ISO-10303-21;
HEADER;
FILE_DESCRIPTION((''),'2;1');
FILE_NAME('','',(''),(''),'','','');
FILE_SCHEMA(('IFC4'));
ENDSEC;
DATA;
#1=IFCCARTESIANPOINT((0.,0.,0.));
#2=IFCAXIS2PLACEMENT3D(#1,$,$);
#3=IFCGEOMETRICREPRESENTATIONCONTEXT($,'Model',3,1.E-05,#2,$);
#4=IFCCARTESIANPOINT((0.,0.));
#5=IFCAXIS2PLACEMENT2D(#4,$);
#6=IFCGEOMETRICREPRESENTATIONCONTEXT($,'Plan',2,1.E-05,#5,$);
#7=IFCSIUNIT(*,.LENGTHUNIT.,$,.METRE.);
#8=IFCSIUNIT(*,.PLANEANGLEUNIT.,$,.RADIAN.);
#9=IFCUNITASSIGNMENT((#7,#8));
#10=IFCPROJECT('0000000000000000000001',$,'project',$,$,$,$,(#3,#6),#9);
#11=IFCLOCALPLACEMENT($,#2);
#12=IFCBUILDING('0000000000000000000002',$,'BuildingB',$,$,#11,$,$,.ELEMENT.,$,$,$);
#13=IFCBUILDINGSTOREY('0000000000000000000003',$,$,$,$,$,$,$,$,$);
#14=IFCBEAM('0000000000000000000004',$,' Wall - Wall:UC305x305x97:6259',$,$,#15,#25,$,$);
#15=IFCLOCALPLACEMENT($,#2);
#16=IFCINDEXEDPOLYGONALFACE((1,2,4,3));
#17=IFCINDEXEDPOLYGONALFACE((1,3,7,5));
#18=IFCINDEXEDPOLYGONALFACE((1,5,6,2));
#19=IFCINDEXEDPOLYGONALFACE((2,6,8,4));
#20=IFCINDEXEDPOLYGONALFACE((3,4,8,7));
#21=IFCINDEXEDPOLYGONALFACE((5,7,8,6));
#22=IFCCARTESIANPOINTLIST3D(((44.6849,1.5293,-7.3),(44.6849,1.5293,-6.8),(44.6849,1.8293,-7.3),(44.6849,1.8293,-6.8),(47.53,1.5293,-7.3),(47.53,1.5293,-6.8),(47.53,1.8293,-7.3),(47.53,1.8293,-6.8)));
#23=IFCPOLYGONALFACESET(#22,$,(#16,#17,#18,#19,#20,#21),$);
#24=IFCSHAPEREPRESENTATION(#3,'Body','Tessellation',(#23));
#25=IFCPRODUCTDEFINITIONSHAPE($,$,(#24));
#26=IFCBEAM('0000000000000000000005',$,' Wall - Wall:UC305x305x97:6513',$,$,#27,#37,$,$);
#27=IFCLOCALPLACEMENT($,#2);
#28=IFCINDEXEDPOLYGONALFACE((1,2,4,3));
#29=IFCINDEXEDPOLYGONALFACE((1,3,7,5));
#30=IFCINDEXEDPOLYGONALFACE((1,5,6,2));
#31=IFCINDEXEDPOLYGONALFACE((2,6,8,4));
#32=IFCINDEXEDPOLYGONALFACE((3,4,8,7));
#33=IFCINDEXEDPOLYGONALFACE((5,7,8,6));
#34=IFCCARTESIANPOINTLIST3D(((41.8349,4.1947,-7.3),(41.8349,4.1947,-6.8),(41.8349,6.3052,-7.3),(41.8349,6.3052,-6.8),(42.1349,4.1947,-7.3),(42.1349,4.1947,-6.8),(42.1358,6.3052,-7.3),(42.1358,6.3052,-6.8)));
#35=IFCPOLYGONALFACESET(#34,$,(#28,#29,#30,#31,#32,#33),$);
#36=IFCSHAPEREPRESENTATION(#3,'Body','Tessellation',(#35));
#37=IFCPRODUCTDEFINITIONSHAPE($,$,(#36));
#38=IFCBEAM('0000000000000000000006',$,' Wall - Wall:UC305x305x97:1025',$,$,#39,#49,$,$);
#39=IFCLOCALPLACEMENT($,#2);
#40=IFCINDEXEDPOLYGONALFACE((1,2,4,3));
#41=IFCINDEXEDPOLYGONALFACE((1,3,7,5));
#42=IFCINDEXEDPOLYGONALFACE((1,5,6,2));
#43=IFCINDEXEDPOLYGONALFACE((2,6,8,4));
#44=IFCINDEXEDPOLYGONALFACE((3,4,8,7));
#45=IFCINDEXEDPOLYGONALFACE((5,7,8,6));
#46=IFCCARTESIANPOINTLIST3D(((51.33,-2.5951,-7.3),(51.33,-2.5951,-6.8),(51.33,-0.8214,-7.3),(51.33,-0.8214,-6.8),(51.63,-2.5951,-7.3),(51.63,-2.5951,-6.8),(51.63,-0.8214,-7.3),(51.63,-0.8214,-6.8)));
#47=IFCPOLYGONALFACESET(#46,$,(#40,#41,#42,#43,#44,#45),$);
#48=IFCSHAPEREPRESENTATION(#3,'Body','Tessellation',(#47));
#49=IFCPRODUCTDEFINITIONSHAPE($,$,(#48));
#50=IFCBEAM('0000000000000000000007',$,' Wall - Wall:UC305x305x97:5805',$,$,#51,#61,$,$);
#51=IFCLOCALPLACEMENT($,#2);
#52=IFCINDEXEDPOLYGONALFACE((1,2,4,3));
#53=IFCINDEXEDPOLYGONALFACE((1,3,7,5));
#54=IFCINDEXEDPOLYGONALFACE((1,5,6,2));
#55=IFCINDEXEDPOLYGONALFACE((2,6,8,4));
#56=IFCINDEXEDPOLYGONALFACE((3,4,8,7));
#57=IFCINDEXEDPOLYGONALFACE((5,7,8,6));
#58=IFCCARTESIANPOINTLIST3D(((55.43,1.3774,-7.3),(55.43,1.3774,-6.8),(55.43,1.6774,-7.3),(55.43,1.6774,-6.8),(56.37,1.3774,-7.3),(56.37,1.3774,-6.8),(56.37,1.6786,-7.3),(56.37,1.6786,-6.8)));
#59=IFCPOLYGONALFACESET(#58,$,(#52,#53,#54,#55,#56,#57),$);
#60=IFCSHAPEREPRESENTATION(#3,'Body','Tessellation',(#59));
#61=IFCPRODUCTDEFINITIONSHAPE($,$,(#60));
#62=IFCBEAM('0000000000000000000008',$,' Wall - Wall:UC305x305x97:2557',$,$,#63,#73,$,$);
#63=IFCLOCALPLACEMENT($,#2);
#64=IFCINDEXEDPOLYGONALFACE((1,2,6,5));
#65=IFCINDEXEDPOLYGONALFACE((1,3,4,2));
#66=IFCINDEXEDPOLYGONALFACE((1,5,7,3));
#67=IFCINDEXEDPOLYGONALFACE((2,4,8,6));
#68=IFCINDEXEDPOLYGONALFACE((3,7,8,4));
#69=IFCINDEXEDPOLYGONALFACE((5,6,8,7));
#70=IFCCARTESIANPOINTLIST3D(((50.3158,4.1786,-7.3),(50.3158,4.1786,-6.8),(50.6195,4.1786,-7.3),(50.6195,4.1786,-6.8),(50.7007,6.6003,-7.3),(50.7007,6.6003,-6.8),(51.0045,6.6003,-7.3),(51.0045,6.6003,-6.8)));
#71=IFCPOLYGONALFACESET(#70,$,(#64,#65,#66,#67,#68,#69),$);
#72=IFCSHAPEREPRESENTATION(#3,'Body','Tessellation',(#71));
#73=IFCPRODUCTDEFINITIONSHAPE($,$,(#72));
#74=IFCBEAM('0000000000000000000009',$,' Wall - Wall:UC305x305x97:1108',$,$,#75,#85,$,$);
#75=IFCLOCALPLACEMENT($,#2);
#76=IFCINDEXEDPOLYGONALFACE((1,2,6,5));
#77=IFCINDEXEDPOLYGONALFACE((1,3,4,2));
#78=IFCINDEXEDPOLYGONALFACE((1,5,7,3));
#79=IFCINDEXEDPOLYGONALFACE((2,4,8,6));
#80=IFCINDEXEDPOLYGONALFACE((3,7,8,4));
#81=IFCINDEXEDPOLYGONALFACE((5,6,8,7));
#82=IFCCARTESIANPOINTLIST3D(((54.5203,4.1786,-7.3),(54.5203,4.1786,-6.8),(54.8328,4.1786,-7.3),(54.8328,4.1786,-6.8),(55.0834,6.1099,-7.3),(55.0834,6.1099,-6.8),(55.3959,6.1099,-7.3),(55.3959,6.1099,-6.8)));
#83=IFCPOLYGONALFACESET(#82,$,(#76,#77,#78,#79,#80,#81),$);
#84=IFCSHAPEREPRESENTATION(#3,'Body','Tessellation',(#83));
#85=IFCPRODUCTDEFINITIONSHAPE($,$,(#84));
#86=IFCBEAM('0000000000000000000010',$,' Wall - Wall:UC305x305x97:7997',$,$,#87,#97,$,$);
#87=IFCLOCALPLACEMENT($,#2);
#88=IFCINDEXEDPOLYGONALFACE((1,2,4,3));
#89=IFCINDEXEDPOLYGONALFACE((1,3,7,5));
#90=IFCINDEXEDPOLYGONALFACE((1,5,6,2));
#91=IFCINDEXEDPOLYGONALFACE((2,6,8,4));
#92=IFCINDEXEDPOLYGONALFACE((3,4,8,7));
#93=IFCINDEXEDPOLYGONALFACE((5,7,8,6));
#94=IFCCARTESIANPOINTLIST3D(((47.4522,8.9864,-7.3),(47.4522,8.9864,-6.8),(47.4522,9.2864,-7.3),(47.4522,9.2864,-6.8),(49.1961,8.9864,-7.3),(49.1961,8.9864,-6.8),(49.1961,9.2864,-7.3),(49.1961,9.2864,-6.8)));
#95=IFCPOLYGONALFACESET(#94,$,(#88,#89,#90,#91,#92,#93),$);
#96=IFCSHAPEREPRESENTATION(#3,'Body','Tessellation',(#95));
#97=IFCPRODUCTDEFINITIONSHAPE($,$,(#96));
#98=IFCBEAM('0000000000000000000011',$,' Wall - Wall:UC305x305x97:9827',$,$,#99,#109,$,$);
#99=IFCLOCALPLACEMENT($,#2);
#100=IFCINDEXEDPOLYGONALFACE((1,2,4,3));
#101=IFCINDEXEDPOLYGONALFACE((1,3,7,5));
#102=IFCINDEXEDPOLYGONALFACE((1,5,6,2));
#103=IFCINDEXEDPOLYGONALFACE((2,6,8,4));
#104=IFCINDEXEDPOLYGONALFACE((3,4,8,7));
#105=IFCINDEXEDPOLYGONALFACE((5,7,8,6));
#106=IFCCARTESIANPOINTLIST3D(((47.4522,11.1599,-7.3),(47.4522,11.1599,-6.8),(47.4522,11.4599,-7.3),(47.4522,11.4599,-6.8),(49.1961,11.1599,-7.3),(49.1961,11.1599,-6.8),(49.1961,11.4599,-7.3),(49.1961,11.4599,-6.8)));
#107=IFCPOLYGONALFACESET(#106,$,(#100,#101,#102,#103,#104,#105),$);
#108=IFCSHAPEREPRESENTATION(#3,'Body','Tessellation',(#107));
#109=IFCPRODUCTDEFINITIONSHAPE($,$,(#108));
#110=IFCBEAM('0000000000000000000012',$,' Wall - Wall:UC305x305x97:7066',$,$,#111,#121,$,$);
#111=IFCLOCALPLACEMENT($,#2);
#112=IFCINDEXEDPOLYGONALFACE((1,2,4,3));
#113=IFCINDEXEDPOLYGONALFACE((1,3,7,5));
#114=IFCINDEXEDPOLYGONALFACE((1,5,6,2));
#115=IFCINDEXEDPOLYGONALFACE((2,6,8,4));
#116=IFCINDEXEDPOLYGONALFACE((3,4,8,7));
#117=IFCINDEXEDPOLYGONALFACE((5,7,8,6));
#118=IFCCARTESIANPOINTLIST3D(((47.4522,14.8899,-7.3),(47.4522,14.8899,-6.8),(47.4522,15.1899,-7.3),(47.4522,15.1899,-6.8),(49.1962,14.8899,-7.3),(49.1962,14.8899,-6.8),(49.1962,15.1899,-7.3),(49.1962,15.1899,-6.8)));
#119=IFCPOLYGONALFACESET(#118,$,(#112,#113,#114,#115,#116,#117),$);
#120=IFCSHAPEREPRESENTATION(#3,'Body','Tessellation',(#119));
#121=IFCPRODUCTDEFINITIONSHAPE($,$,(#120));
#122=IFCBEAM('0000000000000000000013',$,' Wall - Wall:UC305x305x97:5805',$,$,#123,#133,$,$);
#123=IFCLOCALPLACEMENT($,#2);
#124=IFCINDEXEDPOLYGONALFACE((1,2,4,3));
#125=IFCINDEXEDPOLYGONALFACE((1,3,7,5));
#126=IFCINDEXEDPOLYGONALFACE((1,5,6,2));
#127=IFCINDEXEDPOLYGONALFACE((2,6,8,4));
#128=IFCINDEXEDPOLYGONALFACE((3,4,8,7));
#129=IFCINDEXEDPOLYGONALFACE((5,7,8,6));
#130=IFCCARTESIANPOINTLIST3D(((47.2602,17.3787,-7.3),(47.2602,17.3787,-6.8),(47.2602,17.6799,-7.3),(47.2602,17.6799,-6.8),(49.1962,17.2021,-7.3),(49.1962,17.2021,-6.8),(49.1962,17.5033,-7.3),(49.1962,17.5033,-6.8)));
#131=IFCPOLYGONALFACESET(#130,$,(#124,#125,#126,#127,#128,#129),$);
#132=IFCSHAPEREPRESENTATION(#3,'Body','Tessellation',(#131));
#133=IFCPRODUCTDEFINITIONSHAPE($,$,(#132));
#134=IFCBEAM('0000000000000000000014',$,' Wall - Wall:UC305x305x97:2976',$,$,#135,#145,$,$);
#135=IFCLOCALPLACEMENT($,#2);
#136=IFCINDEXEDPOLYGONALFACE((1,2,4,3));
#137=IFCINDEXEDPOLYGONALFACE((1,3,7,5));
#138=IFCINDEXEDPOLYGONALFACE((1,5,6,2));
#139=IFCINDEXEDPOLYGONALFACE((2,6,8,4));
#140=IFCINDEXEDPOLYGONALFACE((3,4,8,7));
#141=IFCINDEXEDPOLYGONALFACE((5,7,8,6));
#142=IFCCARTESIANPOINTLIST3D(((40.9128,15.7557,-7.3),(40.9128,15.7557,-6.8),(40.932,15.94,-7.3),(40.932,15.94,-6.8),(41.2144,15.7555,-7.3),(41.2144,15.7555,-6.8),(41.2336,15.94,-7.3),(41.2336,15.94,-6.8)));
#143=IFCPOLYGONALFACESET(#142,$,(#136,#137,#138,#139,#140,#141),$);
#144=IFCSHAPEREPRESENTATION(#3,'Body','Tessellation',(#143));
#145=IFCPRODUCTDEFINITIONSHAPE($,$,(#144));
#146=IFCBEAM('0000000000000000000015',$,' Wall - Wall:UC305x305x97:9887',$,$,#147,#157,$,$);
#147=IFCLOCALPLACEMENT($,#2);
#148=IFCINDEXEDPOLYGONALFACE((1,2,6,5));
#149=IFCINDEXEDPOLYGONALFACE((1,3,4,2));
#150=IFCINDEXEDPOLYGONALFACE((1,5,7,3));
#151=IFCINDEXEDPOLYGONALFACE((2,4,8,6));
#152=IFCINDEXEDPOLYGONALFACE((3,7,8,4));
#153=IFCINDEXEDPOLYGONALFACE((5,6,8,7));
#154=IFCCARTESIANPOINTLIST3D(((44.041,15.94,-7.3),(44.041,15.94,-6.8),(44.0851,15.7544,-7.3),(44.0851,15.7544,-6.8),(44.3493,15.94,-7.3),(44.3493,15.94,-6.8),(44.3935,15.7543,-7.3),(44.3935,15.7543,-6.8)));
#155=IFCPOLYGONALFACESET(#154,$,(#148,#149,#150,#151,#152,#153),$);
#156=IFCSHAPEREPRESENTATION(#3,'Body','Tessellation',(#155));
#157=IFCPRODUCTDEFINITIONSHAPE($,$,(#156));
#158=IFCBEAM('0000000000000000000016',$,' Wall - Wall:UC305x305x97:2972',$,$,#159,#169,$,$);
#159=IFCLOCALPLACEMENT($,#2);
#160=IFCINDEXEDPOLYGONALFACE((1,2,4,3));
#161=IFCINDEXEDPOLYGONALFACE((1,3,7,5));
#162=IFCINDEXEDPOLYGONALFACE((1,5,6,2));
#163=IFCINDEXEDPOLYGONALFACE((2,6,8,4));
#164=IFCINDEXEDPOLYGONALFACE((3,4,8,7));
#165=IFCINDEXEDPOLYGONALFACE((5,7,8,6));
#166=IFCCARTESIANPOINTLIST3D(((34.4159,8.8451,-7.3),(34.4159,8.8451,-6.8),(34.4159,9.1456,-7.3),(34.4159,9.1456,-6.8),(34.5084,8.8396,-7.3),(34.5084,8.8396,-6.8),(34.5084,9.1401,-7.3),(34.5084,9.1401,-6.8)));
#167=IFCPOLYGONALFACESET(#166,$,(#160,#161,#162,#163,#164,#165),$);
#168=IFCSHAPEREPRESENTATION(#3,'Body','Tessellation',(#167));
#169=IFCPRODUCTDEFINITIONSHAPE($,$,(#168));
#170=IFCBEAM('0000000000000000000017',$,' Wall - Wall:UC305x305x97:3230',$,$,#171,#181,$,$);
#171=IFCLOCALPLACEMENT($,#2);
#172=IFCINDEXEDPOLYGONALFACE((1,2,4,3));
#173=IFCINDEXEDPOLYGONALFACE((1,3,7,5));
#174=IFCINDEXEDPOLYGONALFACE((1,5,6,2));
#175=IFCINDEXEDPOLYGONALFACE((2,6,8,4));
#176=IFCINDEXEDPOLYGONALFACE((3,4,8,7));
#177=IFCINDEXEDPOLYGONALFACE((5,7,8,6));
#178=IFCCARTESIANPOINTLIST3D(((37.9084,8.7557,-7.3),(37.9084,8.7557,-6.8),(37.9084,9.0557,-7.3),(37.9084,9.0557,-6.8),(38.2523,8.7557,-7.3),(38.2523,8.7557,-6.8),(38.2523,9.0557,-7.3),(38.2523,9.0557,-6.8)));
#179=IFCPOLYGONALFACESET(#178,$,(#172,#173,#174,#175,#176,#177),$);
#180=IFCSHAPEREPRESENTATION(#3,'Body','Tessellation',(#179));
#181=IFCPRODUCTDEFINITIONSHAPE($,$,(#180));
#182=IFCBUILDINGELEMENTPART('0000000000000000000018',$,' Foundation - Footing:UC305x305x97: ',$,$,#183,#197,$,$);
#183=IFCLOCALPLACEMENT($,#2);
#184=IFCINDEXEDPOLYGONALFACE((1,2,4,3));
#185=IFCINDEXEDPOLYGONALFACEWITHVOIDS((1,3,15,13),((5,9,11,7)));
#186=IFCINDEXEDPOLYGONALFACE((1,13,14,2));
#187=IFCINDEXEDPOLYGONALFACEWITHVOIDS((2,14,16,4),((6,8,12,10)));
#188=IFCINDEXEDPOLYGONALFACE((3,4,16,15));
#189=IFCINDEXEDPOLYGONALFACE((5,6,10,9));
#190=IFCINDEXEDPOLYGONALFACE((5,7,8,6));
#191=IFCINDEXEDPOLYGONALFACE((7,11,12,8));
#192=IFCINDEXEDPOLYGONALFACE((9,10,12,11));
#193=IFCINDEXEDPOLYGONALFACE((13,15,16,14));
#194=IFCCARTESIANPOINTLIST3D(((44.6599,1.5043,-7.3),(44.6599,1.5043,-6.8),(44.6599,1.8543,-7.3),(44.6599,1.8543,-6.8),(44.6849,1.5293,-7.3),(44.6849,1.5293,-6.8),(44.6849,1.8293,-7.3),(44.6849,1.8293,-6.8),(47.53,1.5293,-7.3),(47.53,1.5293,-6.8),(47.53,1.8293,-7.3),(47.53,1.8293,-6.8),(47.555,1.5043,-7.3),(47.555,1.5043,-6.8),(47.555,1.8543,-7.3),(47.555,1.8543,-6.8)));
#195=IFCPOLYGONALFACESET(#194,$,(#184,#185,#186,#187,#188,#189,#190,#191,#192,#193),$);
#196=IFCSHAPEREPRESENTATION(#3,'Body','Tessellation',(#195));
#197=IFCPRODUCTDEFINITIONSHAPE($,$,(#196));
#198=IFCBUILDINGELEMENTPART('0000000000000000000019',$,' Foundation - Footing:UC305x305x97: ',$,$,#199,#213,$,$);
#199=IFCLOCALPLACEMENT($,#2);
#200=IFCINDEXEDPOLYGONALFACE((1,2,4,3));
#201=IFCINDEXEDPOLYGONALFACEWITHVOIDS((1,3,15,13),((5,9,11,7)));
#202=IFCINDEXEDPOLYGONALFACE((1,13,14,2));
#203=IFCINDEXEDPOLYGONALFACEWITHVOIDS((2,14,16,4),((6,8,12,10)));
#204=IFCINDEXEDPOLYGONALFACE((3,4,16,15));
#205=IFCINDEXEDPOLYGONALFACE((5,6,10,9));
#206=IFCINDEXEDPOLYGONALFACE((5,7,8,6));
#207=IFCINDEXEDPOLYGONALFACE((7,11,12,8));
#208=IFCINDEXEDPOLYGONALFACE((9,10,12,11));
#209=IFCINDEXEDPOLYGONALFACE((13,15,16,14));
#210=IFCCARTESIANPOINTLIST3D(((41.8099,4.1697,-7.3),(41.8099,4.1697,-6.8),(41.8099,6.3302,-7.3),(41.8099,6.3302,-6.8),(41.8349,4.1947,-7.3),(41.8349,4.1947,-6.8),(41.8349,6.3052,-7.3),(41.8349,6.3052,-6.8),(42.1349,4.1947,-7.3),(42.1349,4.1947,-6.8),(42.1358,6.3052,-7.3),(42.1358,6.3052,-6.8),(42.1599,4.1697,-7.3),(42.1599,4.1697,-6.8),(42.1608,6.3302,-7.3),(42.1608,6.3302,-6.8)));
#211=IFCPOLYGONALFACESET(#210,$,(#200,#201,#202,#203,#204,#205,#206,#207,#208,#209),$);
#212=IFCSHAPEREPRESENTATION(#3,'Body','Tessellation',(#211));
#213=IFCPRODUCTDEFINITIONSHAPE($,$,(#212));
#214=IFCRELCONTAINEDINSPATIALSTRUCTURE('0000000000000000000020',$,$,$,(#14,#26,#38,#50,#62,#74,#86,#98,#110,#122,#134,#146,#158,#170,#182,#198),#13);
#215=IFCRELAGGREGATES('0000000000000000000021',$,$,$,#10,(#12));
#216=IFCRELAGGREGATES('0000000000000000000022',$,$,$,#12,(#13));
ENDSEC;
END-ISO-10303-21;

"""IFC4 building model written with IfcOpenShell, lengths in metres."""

from ifc_helpers import new_model, si_unit, origin, origin_2d, place, context, project, spatial, polyline, outline, extrude, element, save


model = new_model("IFC4")

# Units and contexts
model_context = context("Model", 3, precision=1e-05, world=origin())
plan_context = context("Plan", 2, precision=1e-05, world=origin_2d())
ifc_project = project(units=[si_unit("LENGTHUNIT", "METRE"), si_unit("PLANEANGLEUNIT", "RADIAN")], contexts=[model_context, plan_context])

# Building, storey
building_placement = place(None, origin())
building = spatial("IfcBuilding", under=ifc_project, at=building_placement, Name="BuildingB", CompositionType="ELEMENT")
storey = spatial("IfcBuildingStorey", under=building)

# Beams
element("IfcBeam", 1, inside=storey, Name=" Wall - Wall:UC305x305x97:6259", context=model_context, shape_type="SweptSolid", body=[
    extrude(outline(polyline([(44.6849, 1.5293, -7.3), (44.6849, 1.8293, -7.3), (47.53, 1.8293, -7.3), (47.53, 1.5293, -7.3), (44.6849, 1.5293, -7.3)])), None, (0.0, 0.0, 1.0), 0.5),
])
element("IfcBeam", 2, inside=storey, Name=" Wall - Wall:UC305x305x97:6513", context=model_context, shape_type="SweptSolid", body=[
    extrude(outline(polyline([(41.8349, 4.1947, -7.3), (42.1349, 4.1947, -7.3), (42.1358, 6.3052, -7.3), (41.8349, 6.3052, -7.3), (41.8349, 4.1947, -7.3)])), None, (0.0, 0.0, 1.0), 0.5),
])
element("IfcBeam", 3, inside=storey, Name=" Wall - Wall:UC305x305x97:1025", context=model_context, shape_type="SweptSolid", body=[
    extrude(outline(polyline([(51.33, -2.5951, -7.3), (51.63, -2.5951, -7.3), (51.63, -0.8214, -7.3), (51.33, -0.8214, -7.3), (51.33, -2.5951, -7.3)])), None, (0.0, 0.0, 1.0), 0.5),
])
element("IfcBeam", 4, inside=storey, Name=" Wall - Wall:UC305x305x97:5805", context=model_context, shape_type="SweptSolid", body=[
    extrude(outline(polyline([(55.43, 1.3774, -7.3), (55.43, 1.6774, -7.3), (56.37, 1.6786, -7.3), (56.37, 1.3774, -7.3), (55.43, 1.3774, -7.3)])), None, (0.0, 0.0, 1.0), 0.5),
])
element("IfcBeam", 5, inside=storey, Name=" Wall - Wall:UC305x305x97:2557", context=model_context, shape_type="SweptSolid", body=[
    extrude(outline(polyline([(50.3158, 4.1786, -7.3), (50.7007, 6.6003, -7.3), (51.0045, 6.6003, -7.3), (50.6195, 4.1786, -7.3), (50.3158, 4.1786, -7.3)])), None, (0.0, 0.0, 1.0), 0.5),
])
element("IfcBeam", 6, inside=storey, Name=" Wall - Wall:UC305x305x97:1108", context=model_context, shape_type="SweptSolid", body=[
    extrude(outline(polyline([(54.8328, 4.1786, -7.3), (54.5203, 4.1786, -7.3), (55.0834, 6.1099, -7.3), (55.3959, 6.1099, -7.3), (54.8328, 4.1786, -7.3)])), None, (0.0, 0.0, 1.0), 0.5),
])
element("IfcBeam", 7, inside=storey, Name=" Wall - Wall:UC305x305x97:7997", context=model_context, shape_type="SweptSolid", body=[
    extrude(outline(polyline([(47.4522, 8.9864, -7.3), (49.1961, 8.9864, -7.3), (49.1961, 9.2864, -7.3), (47.4522, 9.2864, -7.3), (47.4522, 8.9864, -7.3)])), None, (0.0, 0.0, 1.0), 0.5),
])
element("IfcBeam", 8, inside=storey, Name=" Wall - Wall:UC305x305x97:9827", context=model_context, shape_type="SweptSolid", body=[
    extrude(outline(polyline([(47.4522, 11.1599, -7.3), (47.4522, 11.4599, -7.3), (49.1961, 11.4599, -7.3), (49.1961, 11.1599, -7.3), (47.4522, 11.1599, -7.3)])), None, (0.0, 0.0, 1.0), 0.5),
])
element("IfcBeam", 9, inside=storey, Name=" Wall - Wall:UC305x305x97:7066", context=model_context, shape_type="SweptSolid", body=[
    extrude(outline(polyline([(47.4522, 14.8899, -7.3), (47.4522, 15.1899, -7.3), (49.1962, 15.1899, -7.3), (49.1962, 14.8899, -7.3), (47.4522, 14.8899, -7.3)])), None, (0.0, 0.0, 1.0), 0.5),
])
element("IfcBeam", 10, inside=storey, Name=" Wall - Wall:UC305x305x97:5805", context=model_context, shape_type="SweptSolid", body=[
    extrude(outline(polyline([(47.2602, 17.3787, -7.3), (47.2602, 17.6799, -7.3), (49.1962, 17.5033, -7.3), (49.1962, 17.2021, -7.3), (47.2602, 17.3787, -7.3)])), None, (0.0, 0.0, 1.0), 0.5),
])
element("IfcBeam", 11, inside=storey, Name=" Wall - Wall:UC305x305x97:2976", context=model_context, shape_type="SweptSolid", body=[
    extrude(outline(polyline([(40.9128, 15.7557, -7.3), (40.932, 15.94, -7.3), (41.2336, 15.94, -7.3), (41.2144, 15.7555, -7.3), (40.9128, 15.7557, -7.3)])), None, (0.0, 0.0, 1.0), 0.5),
])
element("IfcBeam", 12, inside=storey, Name=" Wall - Wall:UC305x305x97:9887", context=model_context, shape_type="SweptSolid", body=[
    extrude(outline(polyline([(44.0851, 15.7544, -7.3), (44.041, 15.94, -7.3), (44.3493, 15.94, -7.3), (44.3935, 15.7543, -7.3), (44.0851, 15.7544, -7.3)])), None, (0.0, 0.0, 1.0), 0.5),
])
element("IfcBeam", 13, inside=storey, Name=" Wall - Wall:UC305x305x97:2972", context=model_context, shape_type="SweptSolid", body=[
    extrude(outline(polyline([(34.4159, 8.8451, -7.3), (34.5084, 8.8396, -7.3), (34.5084, 9.1401, -7.3), (34.4159, 9.1456, -7.3), (34.4159, 8.8451, -7.3)])), None, (0.0, 0.0, 1.0), 0.5),
])
element("IfcBeam", 14, inside=storey, Name=" Wall - Wall:UC305x305x97:3230", context=model_context, shape_type="SweptSolid", body=[
    extrude(outline(polyline([(37.9084, 8.7557, -7.3), (38.2523, 8.7557, -7.3), (38.2523, 9.0557, -7.3), (37.9084, 9.0557, -7.3), (37.9084, 8.7557, -7.3)])), None, (0.0, 0.0, 1.0), 0.5),
])

# Building element parts, openings
building_element_part_1 = element("IfcBuildingElementPart", 15, inside=storey, Name=" Foundation - Footing:UC305x305x97: ", context=model_context, shape_type="SweptSolid", body=[
    extrude(outline(polyline([(44.6599, 1.5043, -7.3), (44.6599, 1.8543, -7.3), (47.555, 1.8543, -7.3), (47.555, 1.5043, -7.3), (44.6599, 1.5043, -7.3)])), None, (0.0, 0.0, 1.0), 0.5),
])
element("IfcOpeningElement", 16, inside=storey, cuts=building_element_part_1, context=model_context, shape_type="SweptSolid", body=[
    extrude(outline(polyline([(44.6849, 1.5293, -7.3), (44.6849, 1.8293, -7.3), (47.53, 1.8293, -7.3), (47.53, 1.5293, -7.3), (44.6849, 1.5293, -7.3)])), None, (0.0, 0.0, 1.0), 0.5),
])
building_element_part_2 = element("IfcBuildingElementPart", 17, inside=storey, Name=" Foundation - Footing:UC305x305x97: ", context=model_context, shape_type="SweptSolid", body=[
    extrude(outline(polyline([(41.8099, 4.1697, -7.3), (42.1599, 4.1697, -7.3), (42.1608, 6.3302, -7.3), (41.8099, 6.3302, -7.3), (41.8099, 4.1697, -7.3)])), None, (0.0, 0.0, 1.0), 0.5),
])
element("IfcOpeningElement", 18, inside=storey, cuts=building_element_part_2, context=model_context, shape_type="SweptSolid", body=[
    extrude(outline(polyline([(41.8349, 4.1947, -7.3), (42.1349, 4.1947, -7.3), (42.1358, 6.3052, -7.3), (41.8349, 6.3052, -7.3), (41.8349, 4.1947, -7.3)])), None, (0.0, 0.0, 1.0), 0.5),
])

save(model, "model.ifc")
